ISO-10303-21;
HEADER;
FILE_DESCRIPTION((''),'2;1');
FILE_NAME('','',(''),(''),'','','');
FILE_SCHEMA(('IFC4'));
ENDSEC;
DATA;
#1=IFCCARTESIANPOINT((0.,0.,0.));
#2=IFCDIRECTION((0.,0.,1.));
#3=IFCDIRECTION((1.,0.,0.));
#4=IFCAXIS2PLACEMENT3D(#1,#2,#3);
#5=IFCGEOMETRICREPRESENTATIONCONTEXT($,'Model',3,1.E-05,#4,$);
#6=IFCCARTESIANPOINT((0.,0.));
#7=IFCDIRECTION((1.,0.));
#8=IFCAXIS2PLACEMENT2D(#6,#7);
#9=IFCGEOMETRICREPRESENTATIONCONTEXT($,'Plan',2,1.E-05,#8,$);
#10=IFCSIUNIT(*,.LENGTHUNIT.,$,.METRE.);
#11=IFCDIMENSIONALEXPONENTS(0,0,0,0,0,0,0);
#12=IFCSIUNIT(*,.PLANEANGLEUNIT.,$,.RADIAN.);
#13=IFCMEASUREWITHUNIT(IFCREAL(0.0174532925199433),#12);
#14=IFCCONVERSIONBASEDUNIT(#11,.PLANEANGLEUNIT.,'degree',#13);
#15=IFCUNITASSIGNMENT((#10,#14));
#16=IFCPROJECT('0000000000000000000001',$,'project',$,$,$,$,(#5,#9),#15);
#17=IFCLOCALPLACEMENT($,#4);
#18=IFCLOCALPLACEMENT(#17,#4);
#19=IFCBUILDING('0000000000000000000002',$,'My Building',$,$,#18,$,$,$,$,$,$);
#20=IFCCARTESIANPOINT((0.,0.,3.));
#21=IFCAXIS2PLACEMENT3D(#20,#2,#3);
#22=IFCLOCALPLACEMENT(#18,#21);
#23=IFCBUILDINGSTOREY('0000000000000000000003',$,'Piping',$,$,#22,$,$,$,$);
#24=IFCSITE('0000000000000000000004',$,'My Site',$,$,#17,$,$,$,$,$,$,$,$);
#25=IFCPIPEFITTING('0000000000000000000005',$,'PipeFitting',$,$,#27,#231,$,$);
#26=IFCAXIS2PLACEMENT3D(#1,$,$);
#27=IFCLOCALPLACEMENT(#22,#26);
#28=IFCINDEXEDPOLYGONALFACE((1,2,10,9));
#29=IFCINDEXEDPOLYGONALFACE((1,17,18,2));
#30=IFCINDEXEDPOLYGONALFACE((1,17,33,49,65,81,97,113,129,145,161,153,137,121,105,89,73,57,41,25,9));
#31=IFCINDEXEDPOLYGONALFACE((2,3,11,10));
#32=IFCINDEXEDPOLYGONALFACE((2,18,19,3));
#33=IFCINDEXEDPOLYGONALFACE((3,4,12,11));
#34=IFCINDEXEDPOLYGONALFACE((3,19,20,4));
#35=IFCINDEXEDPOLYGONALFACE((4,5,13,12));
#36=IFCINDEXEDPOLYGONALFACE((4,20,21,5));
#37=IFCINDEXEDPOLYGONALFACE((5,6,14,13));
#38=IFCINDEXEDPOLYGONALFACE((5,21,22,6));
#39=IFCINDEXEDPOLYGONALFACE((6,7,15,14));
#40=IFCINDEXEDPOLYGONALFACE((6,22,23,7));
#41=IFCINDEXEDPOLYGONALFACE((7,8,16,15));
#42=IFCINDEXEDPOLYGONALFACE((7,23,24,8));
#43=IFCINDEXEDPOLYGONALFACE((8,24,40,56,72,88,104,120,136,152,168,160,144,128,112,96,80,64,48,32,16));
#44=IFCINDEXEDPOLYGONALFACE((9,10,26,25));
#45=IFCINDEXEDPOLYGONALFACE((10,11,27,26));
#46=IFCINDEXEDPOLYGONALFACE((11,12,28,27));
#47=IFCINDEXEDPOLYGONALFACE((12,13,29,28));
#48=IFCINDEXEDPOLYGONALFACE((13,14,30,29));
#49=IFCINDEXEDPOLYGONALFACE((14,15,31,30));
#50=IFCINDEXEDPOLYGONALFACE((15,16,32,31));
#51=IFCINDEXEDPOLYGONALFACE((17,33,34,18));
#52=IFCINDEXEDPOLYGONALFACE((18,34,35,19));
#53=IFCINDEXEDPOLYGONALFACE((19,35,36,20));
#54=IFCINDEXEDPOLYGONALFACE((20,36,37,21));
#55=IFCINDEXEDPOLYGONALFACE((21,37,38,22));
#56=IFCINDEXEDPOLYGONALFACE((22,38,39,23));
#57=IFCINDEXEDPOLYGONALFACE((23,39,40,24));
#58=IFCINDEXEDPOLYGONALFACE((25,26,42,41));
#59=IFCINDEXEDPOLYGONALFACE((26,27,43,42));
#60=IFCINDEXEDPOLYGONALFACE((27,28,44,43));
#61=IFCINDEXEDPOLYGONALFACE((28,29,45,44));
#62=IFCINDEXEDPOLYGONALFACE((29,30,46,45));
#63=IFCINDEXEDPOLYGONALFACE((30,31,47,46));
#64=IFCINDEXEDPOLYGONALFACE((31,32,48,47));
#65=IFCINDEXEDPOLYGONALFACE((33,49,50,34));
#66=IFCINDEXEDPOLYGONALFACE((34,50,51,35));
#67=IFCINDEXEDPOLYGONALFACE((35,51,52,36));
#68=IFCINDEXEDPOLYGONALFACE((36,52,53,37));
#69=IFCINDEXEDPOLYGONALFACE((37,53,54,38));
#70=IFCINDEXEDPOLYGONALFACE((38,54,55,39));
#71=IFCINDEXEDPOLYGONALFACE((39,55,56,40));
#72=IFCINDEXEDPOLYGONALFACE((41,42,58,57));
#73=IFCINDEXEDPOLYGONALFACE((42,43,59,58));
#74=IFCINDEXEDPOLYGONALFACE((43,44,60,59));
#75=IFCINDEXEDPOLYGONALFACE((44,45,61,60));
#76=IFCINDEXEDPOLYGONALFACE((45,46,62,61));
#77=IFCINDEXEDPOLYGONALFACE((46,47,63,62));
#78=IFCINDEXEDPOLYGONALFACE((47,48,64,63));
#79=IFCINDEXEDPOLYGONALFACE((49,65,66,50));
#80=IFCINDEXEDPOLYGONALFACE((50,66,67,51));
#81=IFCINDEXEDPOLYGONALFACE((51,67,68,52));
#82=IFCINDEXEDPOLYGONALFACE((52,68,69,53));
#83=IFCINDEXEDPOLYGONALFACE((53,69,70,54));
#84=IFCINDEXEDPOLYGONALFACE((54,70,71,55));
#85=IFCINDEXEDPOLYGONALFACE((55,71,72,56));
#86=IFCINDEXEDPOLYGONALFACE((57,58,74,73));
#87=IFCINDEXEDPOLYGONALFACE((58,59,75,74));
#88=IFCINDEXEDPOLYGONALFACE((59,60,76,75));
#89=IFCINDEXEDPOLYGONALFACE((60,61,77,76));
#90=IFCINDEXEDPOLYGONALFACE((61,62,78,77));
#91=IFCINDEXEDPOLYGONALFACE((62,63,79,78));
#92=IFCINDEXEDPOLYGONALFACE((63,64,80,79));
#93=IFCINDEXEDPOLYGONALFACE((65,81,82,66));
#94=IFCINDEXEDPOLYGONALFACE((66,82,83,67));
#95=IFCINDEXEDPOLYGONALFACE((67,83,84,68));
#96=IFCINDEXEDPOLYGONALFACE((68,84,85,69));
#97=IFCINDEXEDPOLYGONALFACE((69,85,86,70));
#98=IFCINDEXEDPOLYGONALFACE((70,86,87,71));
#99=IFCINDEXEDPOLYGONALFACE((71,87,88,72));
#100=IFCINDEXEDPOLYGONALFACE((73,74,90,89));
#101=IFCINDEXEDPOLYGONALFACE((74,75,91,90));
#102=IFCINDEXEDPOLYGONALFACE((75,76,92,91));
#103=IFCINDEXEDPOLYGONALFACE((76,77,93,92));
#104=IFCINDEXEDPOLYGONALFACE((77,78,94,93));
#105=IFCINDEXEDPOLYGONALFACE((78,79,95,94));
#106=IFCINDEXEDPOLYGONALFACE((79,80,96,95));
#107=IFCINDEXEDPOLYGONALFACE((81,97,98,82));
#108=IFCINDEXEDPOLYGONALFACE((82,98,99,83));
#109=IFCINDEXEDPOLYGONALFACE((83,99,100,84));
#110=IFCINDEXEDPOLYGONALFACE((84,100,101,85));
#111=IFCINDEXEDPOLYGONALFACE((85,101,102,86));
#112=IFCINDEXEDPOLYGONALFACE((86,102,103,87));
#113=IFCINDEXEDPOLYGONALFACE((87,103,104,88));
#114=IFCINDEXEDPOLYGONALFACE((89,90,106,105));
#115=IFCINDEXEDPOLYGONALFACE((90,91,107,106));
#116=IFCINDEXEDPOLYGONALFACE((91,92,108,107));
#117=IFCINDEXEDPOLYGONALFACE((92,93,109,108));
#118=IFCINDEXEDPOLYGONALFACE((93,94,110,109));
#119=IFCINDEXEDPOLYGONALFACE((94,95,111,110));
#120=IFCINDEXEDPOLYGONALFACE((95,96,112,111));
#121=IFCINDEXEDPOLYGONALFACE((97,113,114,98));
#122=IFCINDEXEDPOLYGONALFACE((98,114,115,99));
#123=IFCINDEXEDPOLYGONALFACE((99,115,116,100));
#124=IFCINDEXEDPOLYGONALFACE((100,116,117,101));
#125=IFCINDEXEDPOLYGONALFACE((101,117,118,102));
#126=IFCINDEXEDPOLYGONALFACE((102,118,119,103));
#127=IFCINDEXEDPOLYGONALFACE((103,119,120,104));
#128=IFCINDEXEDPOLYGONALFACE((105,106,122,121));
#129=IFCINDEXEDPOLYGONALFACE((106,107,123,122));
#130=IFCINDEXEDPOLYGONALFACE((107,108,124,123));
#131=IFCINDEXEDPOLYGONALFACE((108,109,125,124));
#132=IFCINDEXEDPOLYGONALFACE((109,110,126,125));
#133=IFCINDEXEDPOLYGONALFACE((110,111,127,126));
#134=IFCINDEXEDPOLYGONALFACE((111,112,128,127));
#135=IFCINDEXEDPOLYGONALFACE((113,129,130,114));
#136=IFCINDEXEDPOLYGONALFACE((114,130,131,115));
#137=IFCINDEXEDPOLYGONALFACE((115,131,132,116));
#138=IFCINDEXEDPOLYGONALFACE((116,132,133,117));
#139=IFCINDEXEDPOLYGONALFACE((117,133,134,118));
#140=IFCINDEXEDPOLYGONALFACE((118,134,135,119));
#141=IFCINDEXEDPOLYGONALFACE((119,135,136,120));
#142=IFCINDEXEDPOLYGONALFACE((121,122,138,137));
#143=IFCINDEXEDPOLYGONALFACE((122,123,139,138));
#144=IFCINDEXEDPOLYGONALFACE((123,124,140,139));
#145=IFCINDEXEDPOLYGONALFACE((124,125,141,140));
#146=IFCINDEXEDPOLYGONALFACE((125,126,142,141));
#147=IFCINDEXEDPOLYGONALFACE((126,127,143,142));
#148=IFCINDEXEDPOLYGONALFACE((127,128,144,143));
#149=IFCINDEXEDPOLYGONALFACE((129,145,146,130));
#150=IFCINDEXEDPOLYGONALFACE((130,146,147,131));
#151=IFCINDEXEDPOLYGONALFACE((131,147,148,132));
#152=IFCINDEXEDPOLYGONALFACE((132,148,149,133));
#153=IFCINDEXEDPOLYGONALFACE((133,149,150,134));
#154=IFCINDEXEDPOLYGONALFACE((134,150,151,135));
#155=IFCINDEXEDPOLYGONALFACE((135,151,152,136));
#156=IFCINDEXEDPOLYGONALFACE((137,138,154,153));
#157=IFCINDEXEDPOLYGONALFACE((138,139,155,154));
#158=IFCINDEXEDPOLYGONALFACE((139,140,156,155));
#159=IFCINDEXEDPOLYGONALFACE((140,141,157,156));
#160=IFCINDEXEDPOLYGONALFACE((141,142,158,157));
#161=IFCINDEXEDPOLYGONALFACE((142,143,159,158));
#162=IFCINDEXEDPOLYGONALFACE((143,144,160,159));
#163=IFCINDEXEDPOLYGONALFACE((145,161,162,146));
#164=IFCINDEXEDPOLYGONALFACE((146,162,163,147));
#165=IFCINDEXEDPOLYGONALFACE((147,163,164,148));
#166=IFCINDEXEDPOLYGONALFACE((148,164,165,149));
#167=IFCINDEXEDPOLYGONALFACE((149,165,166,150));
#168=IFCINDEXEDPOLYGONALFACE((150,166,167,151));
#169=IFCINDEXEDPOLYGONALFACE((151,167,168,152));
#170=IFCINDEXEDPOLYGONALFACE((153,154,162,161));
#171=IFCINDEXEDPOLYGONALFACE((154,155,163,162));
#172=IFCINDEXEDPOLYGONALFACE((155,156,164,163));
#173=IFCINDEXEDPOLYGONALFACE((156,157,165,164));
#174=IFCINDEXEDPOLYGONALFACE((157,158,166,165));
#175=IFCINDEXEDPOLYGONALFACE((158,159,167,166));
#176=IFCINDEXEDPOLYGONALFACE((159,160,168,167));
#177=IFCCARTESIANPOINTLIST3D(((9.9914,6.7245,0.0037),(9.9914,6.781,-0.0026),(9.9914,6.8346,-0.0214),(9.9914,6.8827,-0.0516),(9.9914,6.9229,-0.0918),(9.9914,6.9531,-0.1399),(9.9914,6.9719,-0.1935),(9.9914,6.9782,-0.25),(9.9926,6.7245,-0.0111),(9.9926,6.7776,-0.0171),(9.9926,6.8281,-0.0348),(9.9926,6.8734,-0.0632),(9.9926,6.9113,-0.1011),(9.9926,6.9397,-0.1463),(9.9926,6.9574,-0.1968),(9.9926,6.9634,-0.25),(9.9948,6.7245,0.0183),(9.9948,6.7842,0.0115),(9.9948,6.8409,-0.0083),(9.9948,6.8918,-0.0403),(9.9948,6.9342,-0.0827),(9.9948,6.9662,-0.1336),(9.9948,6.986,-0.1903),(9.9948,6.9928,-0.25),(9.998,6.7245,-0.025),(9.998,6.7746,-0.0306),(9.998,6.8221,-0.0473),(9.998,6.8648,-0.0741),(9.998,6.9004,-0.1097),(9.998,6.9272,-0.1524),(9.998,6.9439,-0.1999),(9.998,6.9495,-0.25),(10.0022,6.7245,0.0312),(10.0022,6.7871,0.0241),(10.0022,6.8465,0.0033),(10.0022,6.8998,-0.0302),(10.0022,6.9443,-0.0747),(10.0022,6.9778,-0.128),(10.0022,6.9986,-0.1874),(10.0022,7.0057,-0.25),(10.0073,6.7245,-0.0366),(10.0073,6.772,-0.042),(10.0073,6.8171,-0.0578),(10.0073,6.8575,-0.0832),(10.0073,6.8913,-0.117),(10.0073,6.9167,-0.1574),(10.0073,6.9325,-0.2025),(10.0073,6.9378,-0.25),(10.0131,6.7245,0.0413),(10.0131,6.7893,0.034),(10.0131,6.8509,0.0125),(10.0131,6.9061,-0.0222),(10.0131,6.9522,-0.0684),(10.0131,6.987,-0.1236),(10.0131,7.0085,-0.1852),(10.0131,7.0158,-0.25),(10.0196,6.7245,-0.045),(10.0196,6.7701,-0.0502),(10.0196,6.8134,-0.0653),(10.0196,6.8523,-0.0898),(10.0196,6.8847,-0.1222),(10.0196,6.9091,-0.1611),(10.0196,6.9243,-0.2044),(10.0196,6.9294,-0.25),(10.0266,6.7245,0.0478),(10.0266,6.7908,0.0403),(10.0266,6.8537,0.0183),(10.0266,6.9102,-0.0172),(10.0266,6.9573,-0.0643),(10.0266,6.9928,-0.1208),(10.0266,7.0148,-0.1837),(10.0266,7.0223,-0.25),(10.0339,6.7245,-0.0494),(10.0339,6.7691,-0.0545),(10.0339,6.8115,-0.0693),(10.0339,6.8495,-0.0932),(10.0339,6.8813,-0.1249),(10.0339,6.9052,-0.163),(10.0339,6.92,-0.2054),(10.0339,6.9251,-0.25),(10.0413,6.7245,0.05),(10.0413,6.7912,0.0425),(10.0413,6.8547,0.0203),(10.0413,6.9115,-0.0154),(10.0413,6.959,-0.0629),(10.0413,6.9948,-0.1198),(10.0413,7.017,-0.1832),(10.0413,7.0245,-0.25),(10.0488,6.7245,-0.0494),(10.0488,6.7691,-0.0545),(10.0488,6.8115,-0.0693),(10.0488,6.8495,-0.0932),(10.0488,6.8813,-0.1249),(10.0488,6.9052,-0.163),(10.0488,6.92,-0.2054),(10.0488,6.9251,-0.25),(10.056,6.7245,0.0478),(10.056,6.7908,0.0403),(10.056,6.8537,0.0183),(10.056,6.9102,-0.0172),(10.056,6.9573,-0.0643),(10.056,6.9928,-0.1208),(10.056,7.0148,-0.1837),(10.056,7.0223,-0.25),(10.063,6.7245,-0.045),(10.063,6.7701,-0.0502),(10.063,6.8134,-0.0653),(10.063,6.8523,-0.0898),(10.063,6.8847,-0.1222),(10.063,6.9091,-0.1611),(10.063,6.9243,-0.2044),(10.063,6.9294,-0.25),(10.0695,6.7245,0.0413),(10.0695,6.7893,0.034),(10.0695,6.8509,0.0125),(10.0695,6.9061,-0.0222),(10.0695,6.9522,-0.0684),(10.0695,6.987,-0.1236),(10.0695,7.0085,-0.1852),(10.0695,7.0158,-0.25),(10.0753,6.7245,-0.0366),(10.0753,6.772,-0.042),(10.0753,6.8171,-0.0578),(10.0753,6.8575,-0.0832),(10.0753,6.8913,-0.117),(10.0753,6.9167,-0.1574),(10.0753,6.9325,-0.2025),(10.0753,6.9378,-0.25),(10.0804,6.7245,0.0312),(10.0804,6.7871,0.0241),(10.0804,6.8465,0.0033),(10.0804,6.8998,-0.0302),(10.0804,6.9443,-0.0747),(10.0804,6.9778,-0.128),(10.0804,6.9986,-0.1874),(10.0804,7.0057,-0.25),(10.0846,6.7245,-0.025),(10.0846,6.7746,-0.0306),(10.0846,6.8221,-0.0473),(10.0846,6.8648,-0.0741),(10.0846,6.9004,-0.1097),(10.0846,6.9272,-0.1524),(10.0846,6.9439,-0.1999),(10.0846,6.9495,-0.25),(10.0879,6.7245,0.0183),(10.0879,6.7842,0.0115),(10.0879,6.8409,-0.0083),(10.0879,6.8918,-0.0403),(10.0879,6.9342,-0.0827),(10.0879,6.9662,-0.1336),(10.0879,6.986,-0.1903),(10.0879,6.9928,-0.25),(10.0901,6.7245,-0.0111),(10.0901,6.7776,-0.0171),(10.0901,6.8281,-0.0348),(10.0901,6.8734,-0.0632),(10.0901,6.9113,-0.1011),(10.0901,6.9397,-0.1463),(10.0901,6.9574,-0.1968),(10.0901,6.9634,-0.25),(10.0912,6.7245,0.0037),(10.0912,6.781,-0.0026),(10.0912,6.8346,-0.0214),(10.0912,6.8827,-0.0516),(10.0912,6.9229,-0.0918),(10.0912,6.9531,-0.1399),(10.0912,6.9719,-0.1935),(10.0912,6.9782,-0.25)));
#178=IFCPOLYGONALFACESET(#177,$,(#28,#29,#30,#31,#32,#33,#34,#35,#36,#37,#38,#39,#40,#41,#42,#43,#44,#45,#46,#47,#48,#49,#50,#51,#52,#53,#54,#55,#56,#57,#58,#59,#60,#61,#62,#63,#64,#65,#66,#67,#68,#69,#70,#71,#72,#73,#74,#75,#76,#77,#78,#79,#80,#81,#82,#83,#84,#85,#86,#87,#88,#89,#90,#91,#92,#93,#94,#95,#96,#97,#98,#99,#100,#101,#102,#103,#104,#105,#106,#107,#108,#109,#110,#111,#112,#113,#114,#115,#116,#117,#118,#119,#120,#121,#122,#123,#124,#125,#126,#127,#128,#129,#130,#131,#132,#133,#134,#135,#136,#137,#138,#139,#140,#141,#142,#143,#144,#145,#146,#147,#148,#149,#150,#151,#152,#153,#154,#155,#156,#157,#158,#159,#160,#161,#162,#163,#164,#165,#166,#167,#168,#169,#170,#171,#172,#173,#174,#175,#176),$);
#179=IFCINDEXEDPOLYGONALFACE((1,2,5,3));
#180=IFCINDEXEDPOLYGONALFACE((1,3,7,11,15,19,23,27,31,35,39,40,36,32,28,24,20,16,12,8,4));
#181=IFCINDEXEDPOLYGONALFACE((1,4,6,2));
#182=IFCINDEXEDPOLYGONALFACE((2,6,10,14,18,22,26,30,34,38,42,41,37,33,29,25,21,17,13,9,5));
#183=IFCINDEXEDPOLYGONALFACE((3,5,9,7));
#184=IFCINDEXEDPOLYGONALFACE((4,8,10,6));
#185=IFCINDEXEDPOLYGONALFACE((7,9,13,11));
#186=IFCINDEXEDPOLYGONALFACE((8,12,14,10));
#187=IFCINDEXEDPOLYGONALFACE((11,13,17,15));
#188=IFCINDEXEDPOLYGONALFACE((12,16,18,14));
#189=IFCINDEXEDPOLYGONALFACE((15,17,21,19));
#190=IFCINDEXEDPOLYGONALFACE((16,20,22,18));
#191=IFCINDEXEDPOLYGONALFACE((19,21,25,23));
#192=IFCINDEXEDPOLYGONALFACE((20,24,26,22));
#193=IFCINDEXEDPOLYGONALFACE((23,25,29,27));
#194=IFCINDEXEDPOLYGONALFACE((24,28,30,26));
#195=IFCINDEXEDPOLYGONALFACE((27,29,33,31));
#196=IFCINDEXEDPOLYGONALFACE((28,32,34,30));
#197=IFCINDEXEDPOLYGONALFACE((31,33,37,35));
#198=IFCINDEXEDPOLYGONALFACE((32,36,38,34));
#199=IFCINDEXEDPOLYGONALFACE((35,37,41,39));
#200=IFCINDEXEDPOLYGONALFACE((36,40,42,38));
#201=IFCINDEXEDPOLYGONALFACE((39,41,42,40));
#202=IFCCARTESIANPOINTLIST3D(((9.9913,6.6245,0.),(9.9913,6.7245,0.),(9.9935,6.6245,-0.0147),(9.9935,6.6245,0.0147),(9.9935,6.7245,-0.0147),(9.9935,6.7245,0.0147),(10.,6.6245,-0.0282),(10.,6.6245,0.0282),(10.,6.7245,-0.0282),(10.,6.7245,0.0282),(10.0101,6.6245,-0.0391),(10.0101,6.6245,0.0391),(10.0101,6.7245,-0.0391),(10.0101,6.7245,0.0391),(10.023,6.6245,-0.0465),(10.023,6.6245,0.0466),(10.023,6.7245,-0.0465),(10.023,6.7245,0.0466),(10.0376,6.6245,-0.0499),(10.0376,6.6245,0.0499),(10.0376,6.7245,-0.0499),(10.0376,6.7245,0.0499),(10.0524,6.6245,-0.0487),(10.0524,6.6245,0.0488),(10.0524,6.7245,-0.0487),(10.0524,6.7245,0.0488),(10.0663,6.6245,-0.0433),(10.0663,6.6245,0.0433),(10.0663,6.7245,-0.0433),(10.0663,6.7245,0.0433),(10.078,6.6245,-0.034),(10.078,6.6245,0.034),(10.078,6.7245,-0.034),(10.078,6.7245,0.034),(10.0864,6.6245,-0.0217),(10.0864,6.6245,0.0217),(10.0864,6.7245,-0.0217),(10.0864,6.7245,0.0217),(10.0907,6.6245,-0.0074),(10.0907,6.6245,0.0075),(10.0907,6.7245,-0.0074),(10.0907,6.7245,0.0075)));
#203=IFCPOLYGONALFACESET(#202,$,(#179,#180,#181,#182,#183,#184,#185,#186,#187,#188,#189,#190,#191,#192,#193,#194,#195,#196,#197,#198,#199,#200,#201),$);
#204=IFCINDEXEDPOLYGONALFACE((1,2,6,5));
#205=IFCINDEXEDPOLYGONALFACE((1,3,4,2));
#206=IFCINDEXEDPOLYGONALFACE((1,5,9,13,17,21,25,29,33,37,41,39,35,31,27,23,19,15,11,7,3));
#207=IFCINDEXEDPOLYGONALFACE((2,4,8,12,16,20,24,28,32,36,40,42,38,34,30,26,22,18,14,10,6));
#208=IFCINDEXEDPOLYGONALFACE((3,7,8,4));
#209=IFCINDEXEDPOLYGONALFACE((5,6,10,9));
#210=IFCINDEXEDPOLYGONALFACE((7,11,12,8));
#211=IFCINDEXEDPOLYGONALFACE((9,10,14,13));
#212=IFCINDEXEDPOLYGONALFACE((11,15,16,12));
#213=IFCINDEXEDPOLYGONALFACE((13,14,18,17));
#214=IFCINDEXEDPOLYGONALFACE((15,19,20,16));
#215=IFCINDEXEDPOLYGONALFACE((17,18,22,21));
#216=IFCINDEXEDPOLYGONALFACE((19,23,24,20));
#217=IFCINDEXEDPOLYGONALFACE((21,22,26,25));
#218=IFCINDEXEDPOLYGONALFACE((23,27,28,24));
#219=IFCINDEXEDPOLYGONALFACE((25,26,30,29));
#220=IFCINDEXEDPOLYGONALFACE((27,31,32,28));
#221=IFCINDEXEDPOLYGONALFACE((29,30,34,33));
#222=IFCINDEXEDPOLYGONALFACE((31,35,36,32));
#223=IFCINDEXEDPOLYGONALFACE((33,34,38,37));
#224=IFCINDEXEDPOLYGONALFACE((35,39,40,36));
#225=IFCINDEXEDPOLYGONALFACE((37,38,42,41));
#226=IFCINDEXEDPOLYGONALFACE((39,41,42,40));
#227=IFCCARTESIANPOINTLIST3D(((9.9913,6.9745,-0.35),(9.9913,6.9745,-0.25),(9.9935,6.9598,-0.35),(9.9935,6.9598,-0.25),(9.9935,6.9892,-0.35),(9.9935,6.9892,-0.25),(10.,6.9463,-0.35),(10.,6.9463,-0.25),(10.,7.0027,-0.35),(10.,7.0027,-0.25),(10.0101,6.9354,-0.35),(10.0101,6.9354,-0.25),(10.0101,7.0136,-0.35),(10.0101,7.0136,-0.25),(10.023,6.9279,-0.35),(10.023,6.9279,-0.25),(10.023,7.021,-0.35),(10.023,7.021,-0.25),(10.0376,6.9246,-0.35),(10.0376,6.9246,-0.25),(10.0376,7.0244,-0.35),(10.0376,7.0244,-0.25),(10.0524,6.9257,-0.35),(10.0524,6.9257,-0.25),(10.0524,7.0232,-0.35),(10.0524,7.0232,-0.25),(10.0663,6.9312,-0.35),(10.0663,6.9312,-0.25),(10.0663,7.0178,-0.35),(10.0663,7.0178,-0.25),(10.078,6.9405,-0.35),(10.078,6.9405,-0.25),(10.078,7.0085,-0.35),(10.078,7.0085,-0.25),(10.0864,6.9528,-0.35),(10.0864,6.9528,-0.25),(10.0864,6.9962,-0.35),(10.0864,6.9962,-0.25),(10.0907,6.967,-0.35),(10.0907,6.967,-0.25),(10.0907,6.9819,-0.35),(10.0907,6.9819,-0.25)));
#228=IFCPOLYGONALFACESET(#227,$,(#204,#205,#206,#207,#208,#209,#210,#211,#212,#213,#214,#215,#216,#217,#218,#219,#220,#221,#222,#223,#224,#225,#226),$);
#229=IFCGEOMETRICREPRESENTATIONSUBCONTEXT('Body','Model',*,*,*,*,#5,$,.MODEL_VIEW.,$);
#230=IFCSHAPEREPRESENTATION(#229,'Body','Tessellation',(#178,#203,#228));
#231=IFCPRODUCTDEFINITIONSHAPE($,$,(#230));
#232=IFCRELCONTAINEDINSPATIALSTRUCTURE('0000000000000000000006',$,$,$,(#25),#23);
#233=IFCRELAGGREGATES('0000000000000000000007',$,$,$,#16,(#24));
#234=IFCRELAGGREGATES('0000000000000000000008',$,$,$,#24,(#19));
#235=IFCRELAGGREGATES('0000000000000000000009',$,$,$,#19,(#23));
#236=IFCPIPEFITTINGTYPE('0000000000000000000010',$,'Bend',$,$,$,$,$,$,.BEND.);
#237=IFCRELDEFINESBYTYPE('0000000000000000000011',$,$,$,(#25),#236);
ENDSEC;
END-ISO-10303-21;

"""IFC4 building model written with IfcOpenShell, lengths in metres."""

from ifc_helpers import new_model, entity, si_unit, converted_unit, frame, origin_with_axes, origin_2d_with_axis, place, context, subcontext, project, spatial, circle, extrude, source, transform, mapped, type_object, type_shapes, element, save


model = new_model("IFC4")

# Units and contexts
model_context = context("Model", 3, precision=1e-05, world=origin_with_axes())
plan_context = context("Plan", 2, precision=1e-05, world=origin_2d_with_axis())
body_context = subcontext(model_context, "Body", "Model", "MODEL_VIEW")
ifc_project = project(units=[si_unit("LENGTHUNIT", "METRE"), converted_unit("PLANEANGLEUNIT", "degree", entity("IfcReal", 0.0174532925199433), si_unit("PLANEANGLEUNIT", "RADIAN"), dimensions=[0, 0, 0, 0, 0, 0, 0])], contexts=[model_context, plan_context])

# Site, building, storey
site_placement = place(None, origin_with_axes())
site = spatial("IfcSite", under=ifc_project, at=site_placement, Name="My Site")
building_placement = place(site_placement, origin_with_axes())
building = spatial("IfcBuilding", under=site, at=building_placement, Name="My Building")
storey_placement = place(building_placement, frame((0.0, 0.0, 3.0), z_axis=(0.0, 0.0, 1.0), x_axis=(1.0, 0.0, 0.0)))
storey = spatial("IfcBuildingStorey", under=building, at=storey_placement, Name="Piping")

# Pipe fitting
pipe_fitting_type = type_object("IfcPipeFittingType", Name="Bend", PredefinedType="BEND")
shared_shape = source(origin_with_axes(), body_context, "Body", "SolidModel", [
    entity("IfcSweptDiskSolid", entity("IfcIndexedPolyCurve", entity("IfcCartesianPointList3D", [[0.0, 0.0, 0.1], [0.0, -0.0732, 0.2768], [0.0, -0.25, 0.35]]), [entity("IfcArcIndex", [1, 2, 3])]), 0.05),
    extrude(circle(Radius=0.05), origin_with_axes(), (0.0, 0.0, 1.0), 0.1),
    extrude(circle(Radius=0.05), frame((0.0, -0.25, 0.35), z_axis=(0.0, -1.0, 0.0), x_axis=(1.0, 0.0, 0.0)), (0.0, 0.0, 1.0), 0.1),
])
type_shapes(pipe_fitting_type, [shared_shape])
for number, where, z_axis, x_axis, name in (
    (1, (10.0413, 6.6245, 0.0), (0.0, 1.0, 0.0), (-1.0, 0.0, 0.0), "PipeFitting"),
):
    element("IfcPipeFitting", number, at=place(storey_placement, frame(where, z_axis=z_axis, x_axis=x_axis)), inside=storey, type_object=pipe_fitting_type, Name=name, context=body_context, shape_type="MappedRepresentation", body=[
        mapped(shared_shape, transform((0.0, 0.0, 0.0), x_axis=(1.0, 0.0, 0.0), y_axis=(0.0, 1.0, 0.0), z_axis=(0.0, 0.0, 1.0), scale=1.0)),
    ])

save(model, "model.ifc")
